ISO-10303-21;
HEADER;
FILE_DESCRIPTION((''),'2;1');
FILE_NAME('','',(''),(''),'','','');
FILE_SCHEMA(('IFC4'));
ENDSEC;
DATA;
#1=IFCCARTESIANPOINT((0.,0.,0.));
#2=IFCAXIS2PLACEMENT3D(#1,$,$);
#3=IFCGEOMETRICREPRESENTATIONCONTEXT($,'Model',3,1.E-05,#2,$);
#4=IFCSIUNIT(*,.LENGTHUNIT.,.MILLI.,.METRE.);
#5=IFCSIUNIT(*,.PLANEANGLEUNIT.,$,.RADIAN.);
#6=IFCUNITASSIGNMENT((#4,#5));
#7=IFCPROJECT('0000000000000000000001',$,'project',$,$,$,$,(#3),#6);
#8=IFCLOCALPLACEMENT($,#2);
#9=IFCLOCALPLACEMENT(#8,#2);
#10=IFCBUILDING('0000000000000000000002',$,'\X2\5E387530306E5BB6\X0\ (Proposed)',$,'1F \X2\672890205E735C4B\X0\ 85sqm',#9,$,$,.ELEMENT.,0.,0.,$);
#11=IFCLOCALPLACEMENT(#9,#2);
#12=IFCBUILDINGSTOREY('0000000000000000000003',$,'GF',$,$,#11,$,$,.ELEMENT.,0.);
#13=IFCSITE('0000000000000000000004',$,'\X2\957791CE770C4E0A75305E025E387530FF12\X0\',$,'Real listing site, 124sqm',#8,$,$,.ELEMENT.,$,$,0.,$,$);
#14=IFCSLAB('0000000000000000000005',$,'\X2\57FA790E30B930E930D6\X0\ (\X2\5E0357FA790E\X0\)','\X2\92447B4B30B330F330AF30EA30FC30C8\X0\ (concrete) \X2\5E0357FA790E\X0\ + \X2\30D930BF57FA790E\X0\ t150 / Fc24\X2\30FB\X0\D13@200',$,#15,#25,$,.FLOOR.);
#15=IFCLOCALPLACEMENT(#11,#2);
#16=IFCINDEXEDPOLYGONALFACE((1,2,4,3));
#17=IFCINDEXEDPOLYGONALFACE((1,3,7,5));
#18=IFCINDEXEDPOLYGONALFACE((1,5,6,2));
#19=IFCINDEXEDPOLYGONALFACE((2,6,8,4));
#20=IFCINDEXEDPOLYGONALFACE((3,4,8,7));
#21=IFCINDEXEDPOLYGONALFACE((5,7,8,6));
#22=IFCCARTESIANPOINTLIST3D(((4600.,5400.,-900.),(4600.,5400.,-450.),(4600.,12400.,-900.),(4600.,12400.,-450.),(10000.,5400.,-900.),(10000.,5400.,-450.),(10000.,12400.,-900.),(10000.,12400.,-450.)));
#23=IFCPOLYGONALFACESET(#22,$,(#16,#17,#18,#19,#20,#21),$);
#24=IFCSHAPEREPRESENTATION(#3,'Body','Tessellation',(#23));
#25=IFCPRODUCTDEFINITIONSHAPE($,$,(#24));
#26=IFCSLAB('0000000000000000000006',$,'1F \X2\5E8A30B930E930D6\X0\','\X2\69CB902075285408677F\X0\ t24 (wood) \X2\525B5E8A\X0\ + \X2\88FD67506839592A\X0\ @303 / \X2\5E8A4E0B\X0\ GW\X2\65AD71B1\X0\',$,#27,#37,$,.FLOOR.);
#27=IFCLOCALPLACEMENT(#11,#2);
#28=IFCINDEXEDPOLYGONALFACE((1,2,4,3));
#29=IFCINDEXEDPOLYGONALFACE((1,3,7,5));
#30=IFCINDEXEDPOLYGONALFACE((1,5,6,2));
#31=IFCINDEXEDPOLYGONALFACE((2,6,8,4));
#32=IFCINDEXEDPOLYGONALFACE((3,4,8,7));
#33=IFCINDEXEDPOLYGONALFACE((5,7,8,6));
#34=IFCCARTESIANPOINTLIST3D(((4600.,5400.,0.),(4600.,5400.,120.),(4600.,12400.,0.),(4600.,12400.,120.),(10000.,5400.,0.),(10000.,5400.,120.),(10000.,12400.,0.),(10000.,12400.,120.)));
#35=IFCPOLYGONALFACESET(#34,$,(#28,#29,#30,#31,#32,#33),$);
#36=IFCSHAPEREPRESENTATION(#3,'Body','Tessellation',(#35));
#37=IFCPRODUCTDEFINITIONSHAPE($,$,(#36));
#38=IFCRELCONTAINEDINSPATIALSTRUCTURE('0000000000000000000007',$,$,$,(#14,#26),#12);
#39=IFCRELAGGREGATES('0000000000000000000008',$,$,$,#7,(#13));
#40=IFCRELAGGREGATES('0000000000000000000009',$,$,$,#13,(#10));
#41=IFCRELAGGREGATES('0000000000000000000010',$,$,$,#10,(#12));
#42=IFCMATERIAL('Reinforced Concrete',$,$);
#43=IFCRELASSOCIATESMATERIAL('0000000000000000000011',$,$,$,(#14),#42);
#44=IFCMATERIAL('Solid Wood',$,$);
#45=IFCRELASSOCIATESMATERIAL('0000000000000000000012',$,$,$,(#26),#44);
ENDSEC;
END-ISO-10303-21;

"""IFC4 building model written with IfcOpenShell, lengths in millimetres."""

from ifc_helpers import new_model, si_unit, frame, frame_2d, origin, place, context, project, spatial, rectangle, extrude, material, element, save


model = new_model("IFC4")

# Units and contexts
model_context = context("Model", 3, precision=1e-05, world=origin())
ifc_project = project(units=[si_unit("LENGTHUNIT", "METRE", prefix="MILLI"), si_unit("PLANEANGLEUNIT", "RADIAN")], contexts=[model_context])

# Site, building, storey
site_placement = place(None, origin())
site = spatial("IfcSite", under=ifc_project, at=site_placement, Name="長野県上田市常田２", ObjectType="Real listing site, 124sqm", CompositionType="ELEMENT", RefElevation=0.0)
building_placement = place(site_placement, origin())
building = spatial("IfcBuilding", under=site, at=building_placement, Name="常田の家 (Proposed)", ObjectType="1F 木造平屋 85sqm", CompositionType="ELEMENT", ElevationOfRefHeight=0.0, ElevationOfTerrain=0.0)
storey_placement = place(building_placement, origin())
storey = spatial("IfcBuildingStorey", under=building, at=storey_placement, Name="GF", CompositionType="ELEMENT", Elevation=0.0)

# Slabs
ifc_material_1 = material(Name="Reinforced Concrete")
slab_1_placement = place(storey_placement, frame((2300.0, 2700.0, -450.0)))
element("IfcSlab", 1, at=slab_1_placement, inside=storey, material=ifc_material_1, Name="基礎スラブ (布基礎)", Description="鉄筋コンクリート (concrete) 布基礎 + ベタ基礎 t150 / Fc24・D13@200", PredefinedType="FLOOR", context=model_context, shape_type="SweptSolid", body=[
    extrude(rectangle(XDim=5400.0, YDim=7000.0, at=frame_2d((2700.0, 3500.0))), frame((2300.0, 2700.0, -450.0)), (0.0, 0.0, 1.0), 450.0),
])
ifc_material_2 = material(Name="Solid Wood")
slab_2_placement = place(storey_placement, frame((2300.0, 2700.0, 0.0)))
element("IfcSlab", 2, at=slab_2_placement, inside=storey, material=ifc_material_2, Name="1F 床スラブ", Description="構造用合板 t24 (wood) 剛床 + 製材根太 @303 / 床下 GW断熱", PredefinedType="FLOOR", context=model_context, shape_type="SweptSolid", body=[
    extrude(rectangle(XDim=5400.0, YDim=7000.0, at=frame_2d((2700.0, 3500.0))), frame((2300.0, 2700.0, 0.0)), (0.0, 0.0, 1.0), 120.0),
])

save(model, "model.ifc")
